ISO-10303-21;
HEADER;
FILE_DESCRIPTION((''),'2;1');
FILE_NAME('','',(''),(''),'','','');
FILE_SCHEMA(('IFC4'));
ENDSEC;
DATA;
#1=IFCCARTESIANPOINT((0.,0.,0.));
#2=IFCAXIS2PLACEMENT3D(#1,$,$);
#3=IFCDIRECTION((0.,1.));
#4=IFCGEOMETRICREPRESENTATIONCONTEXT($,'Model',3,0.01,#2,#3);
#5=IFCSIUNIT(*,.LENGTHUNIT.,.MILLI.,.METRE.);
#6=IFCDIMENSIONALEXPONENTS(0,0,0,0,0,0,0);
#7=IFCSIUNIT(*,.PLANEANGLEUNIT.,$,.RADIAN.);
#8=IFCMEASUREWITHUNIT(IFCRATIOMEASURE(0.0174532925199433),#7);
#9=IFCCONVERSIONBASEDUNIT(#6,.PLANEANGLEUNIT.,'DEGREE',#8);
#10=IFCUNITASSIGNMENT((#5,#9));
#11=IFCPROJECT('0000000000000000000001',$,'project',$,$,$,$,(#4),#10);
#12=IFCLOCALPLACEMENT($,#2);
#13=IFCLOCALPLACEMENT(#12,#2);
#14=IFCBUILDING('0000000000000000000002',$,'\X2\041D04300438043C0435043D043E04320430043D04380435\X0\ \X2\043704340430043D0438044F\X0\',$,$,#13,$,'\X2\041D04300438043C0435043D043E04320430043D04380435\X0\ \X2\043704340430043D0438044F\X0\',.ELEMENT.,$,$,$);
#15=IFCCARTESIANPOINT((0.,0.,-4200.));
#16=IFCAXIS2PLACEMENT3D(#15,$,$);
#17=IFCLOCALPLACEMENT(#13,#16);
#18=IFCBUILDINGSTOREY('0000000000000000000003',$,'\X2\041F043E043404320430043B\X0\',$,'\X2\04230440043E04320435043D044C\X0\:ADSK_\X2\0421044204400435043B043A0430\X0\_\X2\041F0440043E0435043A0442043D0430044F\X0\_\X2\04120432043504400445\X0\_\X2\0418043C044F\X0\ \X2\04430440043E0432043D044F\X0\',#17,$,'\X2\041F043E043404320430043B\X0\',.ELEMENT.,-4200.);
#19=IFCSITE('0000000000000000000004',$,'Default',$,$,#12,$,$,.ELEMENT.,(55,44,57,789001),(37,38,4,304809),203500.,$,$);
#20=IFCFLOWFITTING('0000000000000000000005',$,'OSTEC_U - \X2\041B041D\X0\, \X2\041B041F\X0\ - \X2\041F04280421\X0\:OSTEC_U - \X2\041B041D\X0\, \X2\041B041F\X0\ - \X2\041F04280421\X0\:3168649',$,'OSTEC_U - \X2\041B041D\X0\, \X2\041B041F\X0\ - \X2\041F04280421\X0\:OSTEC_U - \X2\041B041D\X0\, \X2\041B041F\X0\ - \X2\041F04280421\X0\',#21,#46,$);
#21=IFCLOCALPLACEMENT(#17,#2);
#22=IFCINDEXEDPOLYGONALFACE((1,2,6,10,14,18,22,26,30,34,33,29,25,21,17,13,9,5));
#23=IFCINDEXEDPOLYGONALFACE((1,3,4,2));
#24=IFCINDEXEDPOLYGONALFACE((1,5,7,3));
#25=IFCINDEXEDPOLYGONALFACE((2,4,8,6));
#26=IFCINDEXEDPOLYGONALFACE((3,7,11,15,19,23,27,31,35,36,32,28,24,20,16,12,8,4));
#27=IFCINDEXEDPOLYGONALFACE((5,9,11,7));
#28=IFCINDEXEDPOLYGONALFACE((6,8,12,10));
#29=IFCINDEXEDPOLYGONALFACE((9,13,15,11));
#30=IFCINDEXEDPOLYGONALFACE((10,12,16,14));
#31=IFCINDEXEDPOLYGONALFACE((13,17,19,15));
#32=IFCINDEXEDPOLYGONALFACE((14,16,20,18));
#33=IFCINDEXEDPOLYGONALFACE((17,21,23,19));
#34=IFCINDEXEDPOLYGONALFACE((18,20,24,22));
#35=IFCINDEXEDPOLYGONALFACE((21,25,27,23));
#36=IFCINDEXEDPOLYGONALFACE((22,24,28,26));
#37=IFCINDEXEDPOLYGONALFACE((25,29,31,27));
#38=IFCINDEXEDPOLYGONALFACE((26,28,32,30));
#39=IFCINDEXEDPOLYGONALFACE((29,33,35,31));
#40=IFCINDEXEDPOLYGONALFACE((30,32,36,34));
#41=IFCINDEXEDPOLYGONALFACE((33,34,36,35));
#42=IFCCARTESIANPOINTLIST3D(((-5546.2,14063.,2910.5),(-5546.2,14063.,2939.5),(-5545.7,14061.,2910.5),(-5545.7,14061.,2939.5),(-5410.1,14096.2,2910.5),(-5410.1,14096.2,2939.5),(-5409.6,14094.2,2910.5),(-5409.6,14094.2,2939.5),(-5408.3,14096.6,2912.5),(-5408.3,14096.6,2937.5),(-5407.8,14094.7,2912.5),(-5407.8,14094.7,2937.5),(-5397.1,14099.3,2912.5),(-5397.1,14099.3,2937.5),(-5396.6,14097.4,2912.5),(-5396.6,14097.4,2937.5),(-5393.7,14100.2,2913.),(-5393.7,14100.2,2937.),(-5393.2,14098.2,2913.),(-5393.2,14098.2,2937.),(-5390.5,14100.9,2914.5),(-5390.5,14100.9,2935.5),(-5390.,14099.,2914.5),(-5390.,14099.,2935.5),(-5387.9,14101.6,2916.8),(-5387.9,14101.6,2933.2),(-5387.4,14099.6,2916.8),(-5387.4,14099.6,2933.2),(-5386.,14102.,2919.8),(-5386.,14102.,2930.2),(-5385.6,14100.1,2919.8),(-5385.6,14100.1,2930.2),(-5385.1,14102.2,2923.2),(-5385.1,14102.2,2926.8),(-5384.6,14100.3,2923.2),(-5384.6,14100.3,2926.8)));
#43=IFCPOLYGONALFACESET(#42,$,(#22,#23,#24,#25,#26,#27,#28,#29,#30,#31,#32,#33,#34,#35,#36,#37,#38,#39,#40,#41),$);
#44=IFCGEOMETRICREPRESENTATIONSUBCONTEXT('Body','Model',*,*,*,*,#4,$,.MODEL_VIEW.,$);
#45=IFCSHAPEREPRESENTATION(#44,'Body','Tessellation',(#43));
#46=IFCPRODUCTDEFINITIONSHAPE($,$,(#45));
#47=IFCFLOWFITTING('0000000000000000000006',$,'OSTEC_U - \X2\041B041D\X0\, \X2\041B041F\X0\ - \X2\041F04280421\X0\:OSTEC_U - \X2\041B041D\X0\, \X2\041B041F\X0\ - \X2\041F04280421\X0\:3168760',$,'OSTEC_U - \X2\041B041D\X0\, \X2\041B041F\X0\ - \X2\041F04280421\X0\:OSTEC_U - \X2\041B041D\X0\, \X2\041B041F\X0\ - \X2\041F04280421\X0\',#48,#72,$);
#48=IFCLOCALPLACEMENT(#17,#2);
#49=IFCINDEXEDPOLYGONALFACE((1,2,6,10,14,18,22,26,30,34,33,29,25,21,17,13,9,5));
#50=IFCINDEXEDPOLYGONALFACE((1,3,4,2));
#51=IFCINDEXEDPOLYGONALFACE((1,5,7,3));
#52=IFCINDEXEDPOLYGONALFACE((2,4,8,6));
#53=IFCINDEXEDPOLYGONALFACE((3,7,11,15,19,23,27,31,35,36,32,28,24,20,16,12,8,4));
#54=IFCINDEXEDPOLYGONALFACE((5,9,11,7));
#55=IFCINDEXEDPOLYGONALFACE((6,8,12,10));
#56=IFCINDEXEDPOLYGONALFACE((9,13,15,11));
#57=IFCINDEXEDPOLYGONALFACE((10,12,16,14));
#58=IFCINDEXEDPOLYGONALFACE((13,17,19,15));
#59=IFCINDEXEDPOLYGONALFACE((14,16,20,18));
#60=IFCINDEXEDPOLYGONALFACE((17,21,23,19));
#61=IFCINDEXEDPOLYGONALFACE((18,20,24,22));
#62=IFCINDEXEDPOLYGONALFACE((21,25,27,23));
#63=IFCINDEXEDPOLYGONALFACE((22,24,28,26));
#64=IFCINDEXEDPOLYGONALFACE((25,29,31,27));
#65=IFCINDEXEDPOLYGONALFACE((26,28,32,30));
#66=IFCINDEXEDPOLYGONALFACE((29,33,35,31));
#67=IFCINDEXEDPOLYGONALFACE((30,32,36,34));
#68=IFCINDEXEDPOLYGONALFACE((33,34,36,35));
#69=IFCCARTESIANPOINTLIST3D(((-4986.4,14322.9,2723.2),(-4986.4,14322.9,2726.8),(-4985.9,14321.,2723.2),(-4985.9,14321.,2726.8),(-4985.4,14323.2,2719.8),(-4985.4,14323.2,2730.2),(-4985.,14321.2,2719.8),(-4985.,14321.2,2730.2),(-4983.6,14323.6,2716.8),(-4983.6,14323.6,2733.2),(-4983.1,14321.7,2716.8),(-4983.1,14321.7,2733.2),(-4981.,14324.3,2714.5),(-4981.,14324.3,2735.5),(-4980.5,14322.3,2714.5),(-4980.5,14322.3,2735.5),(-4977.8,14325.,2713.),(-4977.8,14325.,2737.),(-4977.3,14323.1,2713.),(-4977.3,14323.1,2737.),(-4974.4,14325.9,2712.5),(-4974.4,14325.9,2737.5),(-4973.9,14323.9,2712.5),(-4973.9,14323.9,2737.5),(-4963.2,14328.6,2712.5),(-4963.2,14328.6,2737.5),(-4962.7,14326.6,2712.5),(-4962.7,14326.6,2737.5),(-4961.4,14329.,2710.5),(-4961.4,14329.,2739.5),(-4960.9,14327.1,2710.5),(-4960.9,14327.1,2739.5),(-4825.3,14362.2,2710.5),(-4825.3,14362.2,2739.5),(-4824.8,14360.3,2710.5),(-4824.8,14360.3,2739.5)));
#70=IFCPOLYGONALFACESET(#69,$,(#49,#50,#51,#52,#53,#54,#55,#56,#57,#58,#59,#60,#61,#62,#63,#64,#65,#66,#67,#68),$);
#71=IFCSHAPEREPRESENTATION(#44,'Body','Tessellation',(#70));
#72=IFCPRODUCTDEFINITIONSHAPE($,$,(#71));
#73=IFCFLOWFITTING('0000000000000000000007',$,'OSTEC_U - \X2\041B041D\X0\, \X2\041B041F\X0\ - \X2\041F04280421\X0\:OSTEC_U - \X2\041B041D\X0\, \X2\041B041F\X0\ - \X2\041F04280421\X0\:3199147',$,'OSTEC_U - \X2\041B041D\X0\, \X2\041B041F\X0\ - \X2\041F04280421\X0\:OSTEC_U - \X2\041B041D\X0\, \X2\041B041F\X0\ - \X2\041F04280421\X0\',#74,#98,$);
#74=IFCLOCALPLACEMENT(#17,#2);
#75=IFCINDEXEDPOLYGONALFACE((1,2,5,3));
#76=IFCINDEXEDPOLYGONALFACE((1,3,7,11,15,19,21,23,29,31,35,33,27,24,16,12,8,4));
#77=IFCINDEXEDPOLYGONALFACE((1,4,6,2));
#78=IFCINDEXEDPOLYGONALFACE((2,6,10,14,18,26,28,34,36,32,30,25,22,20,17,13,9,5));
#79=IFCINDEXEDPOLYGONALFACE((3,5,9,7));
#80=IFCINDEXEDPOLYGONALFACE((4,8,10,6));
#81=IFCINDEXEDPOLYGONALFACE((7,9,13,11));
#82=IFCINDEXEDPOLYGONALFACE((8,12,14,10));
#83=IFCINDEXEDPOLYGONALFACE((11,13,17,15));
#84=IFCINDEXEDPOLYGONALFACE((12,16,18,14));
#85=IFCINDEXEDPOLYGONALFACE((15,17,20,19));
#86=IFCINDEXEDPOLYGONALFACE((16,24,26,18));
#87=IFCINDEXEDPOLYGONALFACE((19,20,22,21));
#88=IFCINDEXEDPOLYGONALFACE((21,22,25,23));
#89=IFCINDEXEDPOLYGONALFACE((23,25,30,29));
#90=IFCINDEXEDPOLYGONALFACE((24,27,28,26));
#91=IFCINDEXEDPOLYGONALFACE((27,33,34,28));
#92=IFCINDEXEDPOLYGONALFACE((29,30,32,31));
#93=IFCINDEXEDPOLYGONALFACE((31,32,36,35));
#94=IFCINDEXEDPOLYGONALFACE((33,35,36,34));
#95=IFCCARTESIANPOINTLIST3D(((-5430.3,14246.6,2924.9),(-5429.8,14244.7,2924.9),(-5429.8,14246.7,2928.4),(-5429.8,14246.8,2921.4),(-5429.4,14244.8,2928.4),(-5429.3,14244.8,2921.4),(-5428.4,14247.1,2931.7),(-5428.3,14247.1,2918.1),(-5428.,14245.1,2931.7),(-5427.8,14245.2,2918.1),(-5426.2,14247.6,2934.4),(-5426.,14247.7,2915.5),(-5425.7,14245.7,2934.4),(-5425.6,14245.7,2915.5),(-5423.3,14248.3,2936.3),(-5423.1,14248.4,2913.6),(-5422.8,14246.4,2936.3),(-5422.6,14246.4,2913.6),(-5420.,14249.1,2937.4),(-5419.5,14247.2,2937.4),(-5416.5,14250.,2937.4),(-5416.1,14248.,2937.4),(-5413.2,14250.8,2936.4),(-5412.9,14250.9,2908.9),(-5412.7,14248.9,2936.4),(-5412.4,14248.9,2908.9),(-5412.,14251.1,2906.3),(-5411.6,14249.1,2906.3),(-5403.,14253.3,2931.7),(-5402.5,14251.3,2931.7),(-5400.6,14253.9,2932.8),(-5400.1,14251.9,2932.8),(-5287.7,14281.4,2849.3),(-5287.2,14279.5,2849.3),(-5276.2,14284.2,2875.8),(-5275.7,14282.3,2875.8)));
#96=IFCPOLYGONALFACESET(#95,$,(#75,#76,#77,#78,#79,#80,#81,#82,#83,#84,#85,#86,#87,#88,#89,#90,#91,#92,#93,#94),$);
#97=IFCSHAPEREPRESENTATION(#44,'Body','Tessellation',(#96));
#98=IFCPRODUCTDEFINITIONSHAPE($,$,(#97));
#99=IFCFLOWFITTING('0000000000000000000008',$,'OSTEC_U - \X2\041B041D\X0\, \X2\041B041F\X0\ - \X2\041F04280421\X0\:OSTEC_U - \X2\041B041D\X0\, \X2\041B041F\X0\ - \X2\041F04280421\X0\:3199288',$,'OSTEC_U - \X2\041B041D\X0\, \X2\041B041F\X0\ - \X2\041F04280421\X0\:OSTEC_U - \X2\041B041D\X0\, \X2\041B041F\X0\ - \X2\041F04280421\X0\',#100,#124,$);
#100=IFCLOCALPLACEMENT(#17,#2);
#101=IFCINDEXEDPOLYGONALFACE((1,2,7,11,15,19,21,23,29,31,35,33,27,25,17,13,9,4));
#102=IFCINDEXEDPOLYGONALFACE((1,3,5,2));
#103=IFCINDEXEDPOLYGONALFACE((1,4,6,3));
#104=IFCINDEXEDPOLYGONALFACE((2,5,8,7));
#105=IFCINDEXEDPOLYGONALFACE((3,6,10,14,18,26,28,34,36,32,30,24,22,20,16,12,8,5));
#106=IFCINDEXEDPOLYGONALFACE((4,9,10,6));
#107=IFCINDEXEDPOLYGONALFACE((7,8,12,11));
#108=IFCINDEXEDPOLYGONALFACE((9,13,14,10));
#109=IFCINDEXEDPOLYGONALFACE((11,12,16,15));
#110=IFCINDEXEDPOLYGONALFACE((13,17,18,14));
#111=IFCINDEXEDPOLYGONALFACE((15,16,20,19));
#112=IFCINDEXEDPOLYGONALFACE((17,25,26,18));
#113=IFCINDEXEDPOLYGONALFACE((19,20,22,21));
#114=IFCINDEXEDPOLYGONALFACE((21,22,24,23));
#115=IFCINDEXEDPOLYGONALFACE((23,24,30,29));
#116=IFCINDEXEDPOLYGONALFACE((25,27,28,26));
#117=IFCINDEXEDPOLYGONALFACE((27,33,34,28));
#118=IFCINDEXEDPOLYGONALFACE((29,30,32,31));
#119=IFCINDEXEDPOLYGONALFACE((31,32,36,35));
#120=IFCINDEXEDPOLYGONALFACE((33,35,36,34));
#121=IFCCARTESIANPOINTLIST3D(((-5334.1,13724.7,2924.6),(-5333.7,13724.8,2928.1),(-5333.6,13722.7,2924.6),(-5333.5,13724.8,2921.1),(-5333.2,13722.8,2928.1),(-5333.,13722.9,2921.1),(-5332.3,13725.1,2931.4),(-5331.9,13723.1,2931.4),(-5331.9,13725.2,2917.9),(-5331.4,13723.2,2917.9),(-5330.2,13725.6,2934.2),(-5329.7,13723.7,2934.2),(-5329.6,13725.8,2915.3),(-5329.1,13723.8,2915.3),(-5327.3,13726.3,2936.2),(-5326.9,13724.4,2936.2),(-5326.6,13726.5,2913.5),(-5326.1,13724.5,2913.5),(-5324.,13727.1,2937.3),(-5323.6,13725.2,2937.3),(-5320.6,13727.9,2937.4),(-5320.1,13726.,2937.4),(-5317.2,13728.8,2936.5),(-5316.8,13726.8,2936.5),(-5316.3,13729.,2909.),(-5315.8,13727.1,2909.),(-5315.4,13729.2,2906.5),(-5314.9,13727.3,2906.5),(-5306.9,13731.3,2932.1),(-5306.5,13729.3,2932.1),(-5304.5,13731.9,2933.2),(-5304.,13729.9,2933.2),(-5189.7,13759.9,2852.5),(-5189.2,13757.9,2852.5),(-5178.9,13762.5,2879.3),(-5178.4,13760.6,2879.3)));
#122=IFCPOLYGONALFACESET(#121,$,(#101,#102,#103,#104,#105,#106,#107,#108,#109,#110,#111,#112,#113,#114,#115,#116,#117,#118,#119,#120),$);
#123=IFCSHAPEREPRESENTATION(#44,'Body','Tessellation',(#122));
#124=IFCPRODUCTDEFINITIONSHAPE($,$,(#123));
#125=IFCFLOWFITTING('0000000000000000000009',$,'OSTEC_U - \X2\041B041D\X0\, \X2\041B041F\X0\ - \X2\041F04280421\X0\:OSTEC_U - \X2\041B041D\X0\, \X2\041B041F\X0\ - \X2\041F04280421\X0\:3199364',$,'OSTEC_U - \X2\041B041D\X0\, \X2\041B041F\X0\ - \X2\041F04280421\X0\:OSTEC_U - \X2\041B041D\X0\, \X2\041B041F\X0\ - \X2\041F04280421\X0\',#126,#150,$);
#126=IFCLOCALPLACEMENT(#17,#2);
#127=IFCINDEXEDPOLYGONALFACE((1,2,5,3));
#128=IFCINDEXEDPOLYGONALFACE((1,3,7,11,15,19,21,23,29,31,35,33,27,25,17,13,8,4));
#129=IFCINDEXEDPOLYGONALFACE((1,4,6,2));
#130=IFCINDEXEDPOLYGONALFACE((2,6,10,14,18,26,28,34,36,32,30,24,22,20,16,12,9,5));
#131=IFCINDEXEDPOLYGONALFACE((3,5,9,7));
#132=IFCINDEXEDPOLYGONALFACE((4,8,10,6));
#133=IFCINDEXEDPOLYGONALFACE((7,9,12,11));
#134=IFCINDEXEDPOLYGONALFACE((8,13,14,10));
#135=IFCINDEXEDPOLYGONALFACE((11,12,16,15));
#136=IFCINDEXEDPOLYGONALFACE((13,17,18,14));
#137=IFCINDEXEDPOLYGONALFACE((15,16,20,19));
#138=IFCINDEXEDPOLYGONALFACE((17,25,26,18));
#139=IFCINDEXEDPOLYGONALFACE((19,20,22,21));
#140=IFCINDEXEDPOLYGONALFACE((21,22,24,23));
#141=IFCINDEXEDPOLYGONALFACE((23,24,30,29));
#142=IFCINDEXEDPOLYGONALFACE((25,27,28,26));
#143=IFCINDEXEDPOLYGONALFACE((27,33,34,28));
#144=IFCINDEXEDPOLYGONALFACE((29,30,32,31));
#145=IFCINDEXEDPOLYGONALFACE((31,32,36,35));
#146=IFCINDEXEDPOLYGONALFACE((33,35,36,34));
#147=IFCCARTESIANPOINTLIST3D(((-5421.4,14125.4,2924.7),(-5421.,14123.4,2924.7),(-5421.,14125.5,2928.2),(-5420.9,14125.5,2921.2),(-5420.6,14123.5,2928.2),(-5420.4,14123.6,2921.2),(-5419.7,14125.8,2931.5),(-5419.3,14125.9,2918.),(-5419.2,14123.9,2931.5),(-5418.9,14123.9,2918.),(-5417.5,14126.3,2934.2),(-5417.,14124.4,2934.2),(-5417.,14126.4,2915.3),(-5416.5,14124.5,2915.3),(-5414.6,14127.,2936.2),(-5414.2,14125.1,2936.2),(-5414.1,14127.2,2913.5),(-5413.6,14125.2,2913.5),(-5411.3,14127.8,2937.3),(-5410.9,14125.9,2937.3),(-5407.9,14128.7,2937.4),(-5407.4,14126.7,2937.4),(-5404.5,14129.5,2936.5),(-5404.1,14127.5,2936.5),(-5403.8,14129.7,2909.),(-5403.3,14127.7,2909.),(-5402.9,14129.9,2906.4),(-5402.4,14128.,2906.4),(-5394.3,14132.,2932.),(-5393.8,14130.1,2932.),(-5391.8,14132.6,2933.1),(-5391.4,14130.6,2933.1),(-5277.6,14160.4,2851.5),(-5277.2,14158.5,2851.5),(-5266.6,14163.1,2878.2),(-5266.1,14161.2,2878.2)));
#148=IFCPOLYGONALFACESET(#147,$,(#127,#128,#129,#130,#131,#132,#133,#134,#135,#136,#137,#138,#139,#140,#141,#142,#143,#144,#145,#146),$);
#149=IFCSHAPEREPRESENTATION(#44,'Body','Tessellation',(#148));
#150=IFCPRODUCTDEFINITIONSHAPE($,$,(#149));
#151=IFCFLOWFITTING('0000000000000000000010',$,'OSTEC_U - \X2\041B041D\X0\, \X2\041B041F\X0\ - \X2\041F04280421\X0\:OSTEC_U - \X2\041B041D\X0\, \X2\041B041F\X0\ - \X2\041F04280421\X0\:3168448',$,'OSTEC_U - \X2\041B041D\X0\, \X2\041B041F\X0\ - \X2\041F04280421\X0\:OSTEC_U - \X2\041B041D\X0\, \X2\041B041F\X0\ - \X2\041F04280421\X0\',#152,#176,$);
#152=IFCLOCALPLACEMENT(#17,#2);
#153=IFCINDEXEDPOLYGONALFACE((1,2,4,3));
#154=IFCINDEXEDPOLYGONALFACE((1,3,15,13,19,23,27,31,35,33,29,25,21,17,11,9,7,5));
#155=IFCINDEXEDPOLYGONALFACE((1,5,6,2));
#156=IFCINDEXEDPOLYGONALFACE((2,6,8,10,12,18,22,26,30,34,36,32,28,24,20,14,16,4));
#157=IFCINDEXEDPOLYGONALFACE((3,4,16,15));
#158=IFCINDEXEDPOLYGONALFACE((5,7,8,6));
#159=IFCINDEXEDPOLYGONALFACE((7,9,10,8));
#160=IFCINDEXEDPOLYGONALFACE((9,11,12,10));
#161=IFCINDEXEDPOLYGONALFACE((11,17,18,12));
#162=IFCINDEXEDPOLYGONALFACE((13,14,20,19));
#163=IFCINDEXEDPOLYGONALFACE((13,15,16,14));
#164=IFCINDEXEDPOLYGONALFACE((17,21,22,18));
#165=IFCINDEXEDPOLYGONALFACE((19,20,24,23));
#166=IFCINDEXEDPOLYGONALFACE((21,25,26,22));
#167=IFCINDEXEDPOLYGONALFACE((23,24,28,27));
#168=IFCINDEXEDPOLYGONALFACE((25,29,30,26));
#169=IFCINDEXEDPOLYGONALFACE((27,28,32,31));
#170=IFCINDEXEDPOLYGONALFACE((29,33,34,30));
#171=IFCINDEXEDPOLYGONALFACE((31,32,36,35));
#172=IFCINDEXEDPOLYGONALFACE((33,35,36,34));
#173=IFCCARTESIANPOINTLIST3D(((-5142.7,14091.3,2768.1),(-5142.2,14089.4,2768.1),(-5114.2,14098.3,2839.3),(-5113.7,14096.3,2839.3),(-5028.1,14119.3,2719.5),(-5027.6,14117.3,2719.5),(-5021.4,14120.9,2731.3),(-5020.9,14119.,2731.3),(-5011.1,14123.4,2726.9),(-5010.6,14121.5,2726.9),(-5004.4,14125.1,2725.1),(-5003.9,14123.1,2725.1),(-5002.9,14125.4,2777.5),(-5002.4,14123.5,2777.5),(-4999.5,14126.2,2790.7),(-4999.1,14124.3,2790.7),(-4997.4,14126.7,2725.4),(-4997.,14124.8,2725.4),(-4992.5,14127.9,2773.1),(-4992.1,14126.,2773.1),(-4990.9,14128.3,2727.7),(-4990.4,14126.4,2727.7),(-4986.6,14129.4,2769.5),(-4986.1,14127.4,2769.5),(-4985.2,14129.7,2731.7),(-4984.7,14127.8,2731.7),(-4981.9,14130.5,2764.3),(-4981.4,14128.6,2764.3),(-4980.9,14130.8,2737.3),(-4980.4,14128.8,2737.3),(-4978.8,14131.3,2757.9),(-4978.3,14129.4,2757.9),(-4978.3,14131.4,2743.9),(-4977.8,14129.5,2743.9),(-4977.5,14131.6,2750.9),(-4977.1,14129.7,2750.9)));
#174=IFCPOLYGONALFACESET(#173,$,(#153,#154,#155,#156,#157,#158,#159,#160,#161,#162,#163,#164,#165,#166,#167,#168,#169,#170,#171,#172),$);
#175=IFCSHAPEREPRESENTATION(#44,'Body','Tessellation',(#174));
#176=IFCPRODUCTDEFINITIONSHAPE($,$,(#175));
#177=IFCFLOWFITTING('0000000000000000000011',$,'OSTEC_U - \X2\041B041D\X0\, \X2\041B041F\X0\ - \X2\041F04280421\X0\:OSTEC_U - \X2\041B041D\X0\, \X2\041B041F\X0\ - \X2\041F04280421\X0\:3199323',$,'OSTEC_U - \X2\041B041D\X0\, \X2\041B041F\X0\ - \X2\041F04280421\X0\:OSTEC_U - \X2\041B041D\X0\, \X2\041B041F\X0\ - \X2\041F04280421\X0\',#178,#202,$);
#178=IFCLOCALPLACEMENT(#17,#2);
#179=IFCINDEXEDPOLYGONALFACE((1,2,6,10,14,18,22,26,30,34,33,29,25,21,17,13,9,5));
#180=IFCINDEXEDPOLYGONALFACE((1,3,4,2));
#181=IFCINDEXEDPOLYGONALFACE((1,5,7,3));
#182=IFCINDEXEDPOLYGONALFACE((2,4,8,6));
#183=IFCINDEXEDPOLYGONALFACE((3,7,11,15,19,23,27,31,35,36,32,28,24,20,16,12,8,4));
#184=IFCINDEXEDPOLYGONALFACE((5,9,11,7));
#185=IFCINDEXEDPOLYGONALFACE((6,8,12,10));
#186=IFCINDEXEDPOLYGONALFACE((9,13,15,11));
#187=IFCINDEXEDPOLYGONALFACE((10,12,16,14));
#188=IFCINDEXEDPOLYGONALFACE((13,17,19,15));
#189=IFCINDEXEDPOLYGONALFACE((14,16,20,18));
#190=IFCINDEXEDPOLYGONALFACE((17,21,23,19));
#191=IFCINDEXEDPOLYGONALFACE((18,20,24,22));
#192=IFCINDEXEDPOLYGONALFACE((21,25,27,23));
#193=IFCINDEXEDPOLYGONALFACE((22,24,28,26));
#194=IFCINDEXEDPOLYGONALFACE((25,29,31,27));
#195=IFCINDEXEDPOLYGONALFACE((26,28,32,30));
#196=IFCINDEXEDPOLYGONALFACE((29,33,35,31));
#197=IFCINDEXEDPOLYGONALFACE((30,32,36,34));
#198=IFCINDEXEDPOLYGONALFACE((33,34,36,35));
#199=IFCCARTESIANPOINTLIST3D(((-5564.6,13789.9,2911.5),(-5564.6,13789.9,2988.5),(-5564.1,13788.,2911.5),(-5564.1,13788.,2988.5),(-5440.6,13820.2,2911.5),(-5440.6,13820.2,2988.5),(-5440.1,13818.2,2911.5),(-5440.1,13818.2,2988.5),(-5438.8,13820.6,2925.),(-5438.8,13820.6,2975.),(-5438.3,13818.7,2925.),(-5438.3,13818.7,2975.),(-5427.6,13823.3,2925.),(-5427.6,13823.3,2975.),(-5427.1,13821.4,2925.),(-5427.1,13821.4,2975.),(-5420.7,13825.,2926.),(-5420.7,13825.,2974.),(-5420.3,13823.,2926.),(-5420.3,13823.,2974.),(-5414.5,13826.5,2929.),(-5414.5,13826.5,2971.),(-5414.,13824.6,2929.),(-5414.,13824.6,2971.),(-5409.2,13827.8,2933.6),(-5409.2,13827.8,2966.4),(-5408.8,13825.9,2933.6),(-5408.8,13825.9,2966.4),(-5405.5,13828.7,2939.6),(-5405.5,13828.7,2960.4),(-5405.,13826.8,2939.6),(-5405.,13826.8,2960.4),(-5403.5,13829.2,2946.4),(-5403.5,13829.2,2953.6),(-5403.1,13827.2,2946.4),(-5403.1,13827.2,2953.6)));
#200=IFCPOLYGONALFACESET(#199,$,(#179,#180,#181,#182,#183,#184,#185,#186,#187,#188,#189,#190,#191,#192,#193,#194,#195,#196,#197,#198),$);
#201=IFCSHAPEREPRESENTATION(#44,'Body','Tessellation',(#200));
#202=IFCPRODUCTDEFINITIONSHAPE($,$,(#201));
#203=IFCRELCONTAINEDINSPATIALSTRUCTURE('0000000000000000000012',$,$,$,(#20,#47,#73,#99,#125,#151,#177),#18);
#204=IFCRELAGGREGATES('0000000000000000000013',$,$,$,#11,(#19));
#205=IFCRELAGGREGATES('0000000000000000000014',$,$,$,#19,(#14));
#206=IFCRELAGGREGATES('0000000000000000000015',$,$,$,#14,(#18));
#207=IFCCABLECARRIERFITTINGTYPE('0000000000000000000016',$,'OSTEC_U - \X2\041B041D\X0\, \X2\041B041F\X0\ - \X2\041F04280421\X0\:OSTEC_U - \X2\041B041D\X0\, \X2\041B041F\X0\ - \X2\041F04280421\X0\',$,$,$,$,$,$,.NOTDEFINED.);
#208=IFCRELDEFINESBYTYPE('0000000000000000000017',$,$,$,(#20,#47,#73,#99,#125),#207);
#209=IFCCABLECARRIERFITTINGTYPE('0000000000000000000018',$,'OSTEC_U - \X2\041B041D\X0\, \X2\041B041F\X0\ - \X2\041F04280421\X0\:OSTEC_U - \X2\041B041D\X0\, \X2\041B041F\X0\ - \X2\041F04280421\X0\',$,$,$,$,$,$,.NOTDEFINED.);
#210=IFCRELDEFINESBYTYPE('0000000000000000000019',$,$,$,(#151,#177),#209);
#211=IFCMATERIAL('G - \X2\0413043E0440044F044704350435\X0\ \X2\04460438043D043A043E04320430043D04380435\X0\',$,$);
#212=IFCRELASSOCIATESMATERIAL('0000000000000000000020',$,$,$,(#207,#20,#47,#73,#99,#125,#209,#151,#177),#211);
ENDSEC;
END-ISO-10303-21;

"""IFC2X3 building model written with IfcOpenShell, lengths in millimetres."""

from ifc_helpers import new_model, entity, si_unit, converted_unit, direction, frame, frame_2d, origin, place, context, subcontext, project, spatial, polyline, circle_curve, parameter, trimmed, segment, composite_curve, outline, extrude, source, transform, mapped, material, type_object, type_shapes, element, save


model = new_model("IFC2X3")

# Units and contexts
model_context = context("Model", 3, precision=0.01, world=origin(), true_north=direction((0.0, 1.0)))
body_context = subcontext(model_context, "Body", "Model", "MODEL_VIEW")
ifc_project = project(units=[si_unit("LENGTHUNIT", "METRE", prefix="MILLI"), converted_unit("PLANEANGLEUNIT", "DEGREE", entity("IfcRatioMeasure", 0.0174532925199433), si_unit("PLANEANGLEUNIT", "RADIAN"), dimensions=[0, 0, 0, 0, 0, 0, 0])], contexts=[model_context])

# Site, building, storey
site_placement = place(None, frame((0.0, 0.0, 0.0)))
site = spatial("IfcSite", under=ifc_project, at=site_placement, Name="Default", CompositionType="ELEMENT", RefLatitude=(55, 44, 57, 789001), RefLongitude=(37, 38, 4, 304809), RefElevation=203500.0)
building_placement = place(site_placement, origin())
building = spatial("IfcBuilding", under=site, at=building_placement, Name="Наименование здания", LongName="Наименование здания", CompositionType="ELEMENT")
storey_placement = place(building_placement, frame((0.0, 0.0, -4200.0)))
storey = spatial("IfcBuildingStorey", under=building, at=storey_placement, Name="Подвал", ObjectType="Уровень:ADSK_Стрелка_Проектная_Вверх_Имя уровня", LongName="Подвал", CompositionType="ELEMENT", Elevation=-4200.0)

# Flow fittings
ifc_material = material(Name="G - Горячее цинкование")
cable_carrier_fitting_type_1 = type_object("IfcCableCarrierFittingType", Name="OSTEC_U - ЛН, ЛП - ПШС:OSTEC_U - ЛН, ЛП - ПШС", PredefinedType="NOTDEFINED", material=ifc_material)
shared_shape_1 = source(origin(), body_context, "Body", "SweptSolid", [
    extrude(outline(composite_curve([segment(trimmed(circle_curve(frame_2d((-44.6, 0.0), x_axis=(1.0, 0.0)), 12.5), [parameter(90.0)], [parameter(270.0)], True, "PARAMETER"), True, "CONTINUOUS"), segment(polyline([(-44.6, -12.5), (-33.1, -12.5)]), True, "CONTINUOUS"), segment(polyline([(-33.1, -12.5), (-31.2, -14.5)]), True, "CONTINUOUS"), segment(polyline([(-31.2, -14.5), (108.9, -14.5)]), True, "CONTINUOUS"), segment(polyline([(108.9, -14.5), (108.9, 14.5)]), True, "CONTINUOUS"), segment(polyline([(108.9, 14.5), (-31.2, 14.5)]), True, "CONTINUOUS"), segment(polyline([(-31.2, 14.5), (-33.1, 12.5)]), True, "CONTINUOUS"), segment(polyline([(-33.1, 12.5), (-44.6, 12.5)]), True, "CONTINUOUS")], self_intersect=False)), frame((44.6, 0.0, 0.0)), (0.0, 0.0, 1.0), 2.0),
])
type_shapes(cable_carrier_fitting_type_1, [shared_shape_1])
for number, where, z_axis, x_axis, name in (
    (1, (-5396.6, 14097.4, 2925.0), (-0.236821, 0.971553, 0.0), (-0.971553, -0.236821, 0.0), "OSTEC_U - ЛН, ЛП - ПШС:OSTEC_U - ЛН, ЛП - ПШС:3168649"),
    (2, (-4973.9, 14323.9, 2725.0), (-0.236821, 0.971553, 0.0), (0.971553, 0.236821, 0.0), "OSTEC_U - ЛН, ЛП - ПШС:OSTEC_U - ЛН, ЛП - ПШС:3168760"),
    (3, (-5418.2, 14249.6, 2925.0), (0.236821, -0.971553, 0.0), (0.887558, 0.216347, -0.406737), "OSTEC_U - ЛН, ЛП - ПШС:OSTEC_U - ЛН, ЛП - ПШС:3199147"),
    (4, (-5321.9, 13727.6, 2925.0), (0.236821, -0.971553, 0.0), (0.896628, 0.218557, -0.385085), "OSTEC_U - ЛН, ЛП - ПШС:OSTEC_U - ЛН, ЛП - ПШС:3199288"),
    (5, (-5409.3, 14128.3, 2925.0), (0.236821, -0.971553, 0.0), (0.893779, 0.217863, -0.39204), "OSTEC_U - ЛН, ЛП - ПШС:OSTEC_U - ЛН, ЛП - ПШС:3199364"),
):
    element("IfcFlowFitting", number, at=place(storey_placement, frame(where, z_axis=z_axis, x_axis=x_axis)), inside=storey, type_object=cable_carrier_fitting_type_1, material=ifc_material, Name=name, ObjectType="OSTEC_U - ЛН, ЛП - ПШС:OSTEC_U - ЛН, ЛП - ПШС", context=body_context, shape_type="MappedRepresentation", body=[
        mapped(shared_shape_1, transform((0.0, 0.0, 0.0), scale=1.0)),
    ])
cable_carrier_fitting_type_2 = type_object("IfcCableCarrierFittingType", Name="OSTEC_U - ЛН, ЛП - ПШС:OSTEC_U - ЛН, ЛП - ПШС", PredefinedType="NOTDEFINED", material=ifc_material)
shared_shape_2 = source(origin(), body_context, "Body", "SweptSolid", [
    extrude(outline(composite_curve([segment(trimmed(circle_curve(frame_2d((-41.5, 0.0), x_axis=(1.0, 0.0)), 25.0), [parameter(90.0)], [parameter(270.0)], True, "PARAMETER"), True, "CONTINUOUS"), segment(polyline([(-41.5, -25.0), (-30.0, -25.0)]), True, "CONTINUOUS"), segment(polyline([(-30.0, -25.0), (-28.1, -38.5)]), True, "CONTINUOUS"), segment(polyline([(-28.1, -38.5), (99.5, -38.5)]), True, "CONTINUOUS"), segment(polyline([(99.5, -38.5), (99.5, 38.5)]), True, "CONTINUOUS"), segment(polyline([(99.5, 38.5), (-28.1, 38.5)]), True, "CONTINUOUS"), segment(polyline([(-28.1, 38.5), (-30.0, 25.0)]), True, "CONTINUOUS"), segment(polyline([(-30.0, 25.0), (-41.5, 25.0)]), True, "CONTINUOUS")], self_intersect=False)), frame((41.5, 0.0, 0.0), z_axis=(0.0, 0.0, -1.0), x_axis=(1.0, 0.0, 0.0)), (0.0, 0.0, -1.0), 2.0),
])
type_shapes(cable_carrier_fitting_type_2, [shared_shape_2])
for number, where, z_axis, x_axis, name in (
    (6, (-5001.3, 14123.7, 2750.0), (-0.236821, 0.971553, 0.0), (-0.898257, -0.218954, 0.381042), "OSTEC_U - ЛН, ЛП - ПШС:OSTEC_U - ЛН, ЛП - ПШС:3168448"),
    (7, (-5427.6, 13823.3, 2950.0), (0.236821, -0.971553, 0.0), (-0.971553, -0.236821, 0.0), "OSTEC_U - ЛН, ЛП - ПШС:OSTEC_U - ЛН, ЛП - ПШС:3199323"),
):
    element("IfcFlowFitting", number, at=place(storey_placement, frame(where, z_axis=z_axis, x_axis=x_axis)), inside=storey, type_object=cable_carrier_fitting_type_2, material=ifc_material, Name=name, ObjectType="OSTEC_U - ЛН, ЛП - ПШС:OSTEC_U - ЛН, ЛП - ПШС", context=body_context, shape_type="MappedRepresentation", body=[
        mapped(shared_shape_2, transform((0.0, 0.0, 0.0), scale=1.0)),
    ])

save(model, "model.ifc")
